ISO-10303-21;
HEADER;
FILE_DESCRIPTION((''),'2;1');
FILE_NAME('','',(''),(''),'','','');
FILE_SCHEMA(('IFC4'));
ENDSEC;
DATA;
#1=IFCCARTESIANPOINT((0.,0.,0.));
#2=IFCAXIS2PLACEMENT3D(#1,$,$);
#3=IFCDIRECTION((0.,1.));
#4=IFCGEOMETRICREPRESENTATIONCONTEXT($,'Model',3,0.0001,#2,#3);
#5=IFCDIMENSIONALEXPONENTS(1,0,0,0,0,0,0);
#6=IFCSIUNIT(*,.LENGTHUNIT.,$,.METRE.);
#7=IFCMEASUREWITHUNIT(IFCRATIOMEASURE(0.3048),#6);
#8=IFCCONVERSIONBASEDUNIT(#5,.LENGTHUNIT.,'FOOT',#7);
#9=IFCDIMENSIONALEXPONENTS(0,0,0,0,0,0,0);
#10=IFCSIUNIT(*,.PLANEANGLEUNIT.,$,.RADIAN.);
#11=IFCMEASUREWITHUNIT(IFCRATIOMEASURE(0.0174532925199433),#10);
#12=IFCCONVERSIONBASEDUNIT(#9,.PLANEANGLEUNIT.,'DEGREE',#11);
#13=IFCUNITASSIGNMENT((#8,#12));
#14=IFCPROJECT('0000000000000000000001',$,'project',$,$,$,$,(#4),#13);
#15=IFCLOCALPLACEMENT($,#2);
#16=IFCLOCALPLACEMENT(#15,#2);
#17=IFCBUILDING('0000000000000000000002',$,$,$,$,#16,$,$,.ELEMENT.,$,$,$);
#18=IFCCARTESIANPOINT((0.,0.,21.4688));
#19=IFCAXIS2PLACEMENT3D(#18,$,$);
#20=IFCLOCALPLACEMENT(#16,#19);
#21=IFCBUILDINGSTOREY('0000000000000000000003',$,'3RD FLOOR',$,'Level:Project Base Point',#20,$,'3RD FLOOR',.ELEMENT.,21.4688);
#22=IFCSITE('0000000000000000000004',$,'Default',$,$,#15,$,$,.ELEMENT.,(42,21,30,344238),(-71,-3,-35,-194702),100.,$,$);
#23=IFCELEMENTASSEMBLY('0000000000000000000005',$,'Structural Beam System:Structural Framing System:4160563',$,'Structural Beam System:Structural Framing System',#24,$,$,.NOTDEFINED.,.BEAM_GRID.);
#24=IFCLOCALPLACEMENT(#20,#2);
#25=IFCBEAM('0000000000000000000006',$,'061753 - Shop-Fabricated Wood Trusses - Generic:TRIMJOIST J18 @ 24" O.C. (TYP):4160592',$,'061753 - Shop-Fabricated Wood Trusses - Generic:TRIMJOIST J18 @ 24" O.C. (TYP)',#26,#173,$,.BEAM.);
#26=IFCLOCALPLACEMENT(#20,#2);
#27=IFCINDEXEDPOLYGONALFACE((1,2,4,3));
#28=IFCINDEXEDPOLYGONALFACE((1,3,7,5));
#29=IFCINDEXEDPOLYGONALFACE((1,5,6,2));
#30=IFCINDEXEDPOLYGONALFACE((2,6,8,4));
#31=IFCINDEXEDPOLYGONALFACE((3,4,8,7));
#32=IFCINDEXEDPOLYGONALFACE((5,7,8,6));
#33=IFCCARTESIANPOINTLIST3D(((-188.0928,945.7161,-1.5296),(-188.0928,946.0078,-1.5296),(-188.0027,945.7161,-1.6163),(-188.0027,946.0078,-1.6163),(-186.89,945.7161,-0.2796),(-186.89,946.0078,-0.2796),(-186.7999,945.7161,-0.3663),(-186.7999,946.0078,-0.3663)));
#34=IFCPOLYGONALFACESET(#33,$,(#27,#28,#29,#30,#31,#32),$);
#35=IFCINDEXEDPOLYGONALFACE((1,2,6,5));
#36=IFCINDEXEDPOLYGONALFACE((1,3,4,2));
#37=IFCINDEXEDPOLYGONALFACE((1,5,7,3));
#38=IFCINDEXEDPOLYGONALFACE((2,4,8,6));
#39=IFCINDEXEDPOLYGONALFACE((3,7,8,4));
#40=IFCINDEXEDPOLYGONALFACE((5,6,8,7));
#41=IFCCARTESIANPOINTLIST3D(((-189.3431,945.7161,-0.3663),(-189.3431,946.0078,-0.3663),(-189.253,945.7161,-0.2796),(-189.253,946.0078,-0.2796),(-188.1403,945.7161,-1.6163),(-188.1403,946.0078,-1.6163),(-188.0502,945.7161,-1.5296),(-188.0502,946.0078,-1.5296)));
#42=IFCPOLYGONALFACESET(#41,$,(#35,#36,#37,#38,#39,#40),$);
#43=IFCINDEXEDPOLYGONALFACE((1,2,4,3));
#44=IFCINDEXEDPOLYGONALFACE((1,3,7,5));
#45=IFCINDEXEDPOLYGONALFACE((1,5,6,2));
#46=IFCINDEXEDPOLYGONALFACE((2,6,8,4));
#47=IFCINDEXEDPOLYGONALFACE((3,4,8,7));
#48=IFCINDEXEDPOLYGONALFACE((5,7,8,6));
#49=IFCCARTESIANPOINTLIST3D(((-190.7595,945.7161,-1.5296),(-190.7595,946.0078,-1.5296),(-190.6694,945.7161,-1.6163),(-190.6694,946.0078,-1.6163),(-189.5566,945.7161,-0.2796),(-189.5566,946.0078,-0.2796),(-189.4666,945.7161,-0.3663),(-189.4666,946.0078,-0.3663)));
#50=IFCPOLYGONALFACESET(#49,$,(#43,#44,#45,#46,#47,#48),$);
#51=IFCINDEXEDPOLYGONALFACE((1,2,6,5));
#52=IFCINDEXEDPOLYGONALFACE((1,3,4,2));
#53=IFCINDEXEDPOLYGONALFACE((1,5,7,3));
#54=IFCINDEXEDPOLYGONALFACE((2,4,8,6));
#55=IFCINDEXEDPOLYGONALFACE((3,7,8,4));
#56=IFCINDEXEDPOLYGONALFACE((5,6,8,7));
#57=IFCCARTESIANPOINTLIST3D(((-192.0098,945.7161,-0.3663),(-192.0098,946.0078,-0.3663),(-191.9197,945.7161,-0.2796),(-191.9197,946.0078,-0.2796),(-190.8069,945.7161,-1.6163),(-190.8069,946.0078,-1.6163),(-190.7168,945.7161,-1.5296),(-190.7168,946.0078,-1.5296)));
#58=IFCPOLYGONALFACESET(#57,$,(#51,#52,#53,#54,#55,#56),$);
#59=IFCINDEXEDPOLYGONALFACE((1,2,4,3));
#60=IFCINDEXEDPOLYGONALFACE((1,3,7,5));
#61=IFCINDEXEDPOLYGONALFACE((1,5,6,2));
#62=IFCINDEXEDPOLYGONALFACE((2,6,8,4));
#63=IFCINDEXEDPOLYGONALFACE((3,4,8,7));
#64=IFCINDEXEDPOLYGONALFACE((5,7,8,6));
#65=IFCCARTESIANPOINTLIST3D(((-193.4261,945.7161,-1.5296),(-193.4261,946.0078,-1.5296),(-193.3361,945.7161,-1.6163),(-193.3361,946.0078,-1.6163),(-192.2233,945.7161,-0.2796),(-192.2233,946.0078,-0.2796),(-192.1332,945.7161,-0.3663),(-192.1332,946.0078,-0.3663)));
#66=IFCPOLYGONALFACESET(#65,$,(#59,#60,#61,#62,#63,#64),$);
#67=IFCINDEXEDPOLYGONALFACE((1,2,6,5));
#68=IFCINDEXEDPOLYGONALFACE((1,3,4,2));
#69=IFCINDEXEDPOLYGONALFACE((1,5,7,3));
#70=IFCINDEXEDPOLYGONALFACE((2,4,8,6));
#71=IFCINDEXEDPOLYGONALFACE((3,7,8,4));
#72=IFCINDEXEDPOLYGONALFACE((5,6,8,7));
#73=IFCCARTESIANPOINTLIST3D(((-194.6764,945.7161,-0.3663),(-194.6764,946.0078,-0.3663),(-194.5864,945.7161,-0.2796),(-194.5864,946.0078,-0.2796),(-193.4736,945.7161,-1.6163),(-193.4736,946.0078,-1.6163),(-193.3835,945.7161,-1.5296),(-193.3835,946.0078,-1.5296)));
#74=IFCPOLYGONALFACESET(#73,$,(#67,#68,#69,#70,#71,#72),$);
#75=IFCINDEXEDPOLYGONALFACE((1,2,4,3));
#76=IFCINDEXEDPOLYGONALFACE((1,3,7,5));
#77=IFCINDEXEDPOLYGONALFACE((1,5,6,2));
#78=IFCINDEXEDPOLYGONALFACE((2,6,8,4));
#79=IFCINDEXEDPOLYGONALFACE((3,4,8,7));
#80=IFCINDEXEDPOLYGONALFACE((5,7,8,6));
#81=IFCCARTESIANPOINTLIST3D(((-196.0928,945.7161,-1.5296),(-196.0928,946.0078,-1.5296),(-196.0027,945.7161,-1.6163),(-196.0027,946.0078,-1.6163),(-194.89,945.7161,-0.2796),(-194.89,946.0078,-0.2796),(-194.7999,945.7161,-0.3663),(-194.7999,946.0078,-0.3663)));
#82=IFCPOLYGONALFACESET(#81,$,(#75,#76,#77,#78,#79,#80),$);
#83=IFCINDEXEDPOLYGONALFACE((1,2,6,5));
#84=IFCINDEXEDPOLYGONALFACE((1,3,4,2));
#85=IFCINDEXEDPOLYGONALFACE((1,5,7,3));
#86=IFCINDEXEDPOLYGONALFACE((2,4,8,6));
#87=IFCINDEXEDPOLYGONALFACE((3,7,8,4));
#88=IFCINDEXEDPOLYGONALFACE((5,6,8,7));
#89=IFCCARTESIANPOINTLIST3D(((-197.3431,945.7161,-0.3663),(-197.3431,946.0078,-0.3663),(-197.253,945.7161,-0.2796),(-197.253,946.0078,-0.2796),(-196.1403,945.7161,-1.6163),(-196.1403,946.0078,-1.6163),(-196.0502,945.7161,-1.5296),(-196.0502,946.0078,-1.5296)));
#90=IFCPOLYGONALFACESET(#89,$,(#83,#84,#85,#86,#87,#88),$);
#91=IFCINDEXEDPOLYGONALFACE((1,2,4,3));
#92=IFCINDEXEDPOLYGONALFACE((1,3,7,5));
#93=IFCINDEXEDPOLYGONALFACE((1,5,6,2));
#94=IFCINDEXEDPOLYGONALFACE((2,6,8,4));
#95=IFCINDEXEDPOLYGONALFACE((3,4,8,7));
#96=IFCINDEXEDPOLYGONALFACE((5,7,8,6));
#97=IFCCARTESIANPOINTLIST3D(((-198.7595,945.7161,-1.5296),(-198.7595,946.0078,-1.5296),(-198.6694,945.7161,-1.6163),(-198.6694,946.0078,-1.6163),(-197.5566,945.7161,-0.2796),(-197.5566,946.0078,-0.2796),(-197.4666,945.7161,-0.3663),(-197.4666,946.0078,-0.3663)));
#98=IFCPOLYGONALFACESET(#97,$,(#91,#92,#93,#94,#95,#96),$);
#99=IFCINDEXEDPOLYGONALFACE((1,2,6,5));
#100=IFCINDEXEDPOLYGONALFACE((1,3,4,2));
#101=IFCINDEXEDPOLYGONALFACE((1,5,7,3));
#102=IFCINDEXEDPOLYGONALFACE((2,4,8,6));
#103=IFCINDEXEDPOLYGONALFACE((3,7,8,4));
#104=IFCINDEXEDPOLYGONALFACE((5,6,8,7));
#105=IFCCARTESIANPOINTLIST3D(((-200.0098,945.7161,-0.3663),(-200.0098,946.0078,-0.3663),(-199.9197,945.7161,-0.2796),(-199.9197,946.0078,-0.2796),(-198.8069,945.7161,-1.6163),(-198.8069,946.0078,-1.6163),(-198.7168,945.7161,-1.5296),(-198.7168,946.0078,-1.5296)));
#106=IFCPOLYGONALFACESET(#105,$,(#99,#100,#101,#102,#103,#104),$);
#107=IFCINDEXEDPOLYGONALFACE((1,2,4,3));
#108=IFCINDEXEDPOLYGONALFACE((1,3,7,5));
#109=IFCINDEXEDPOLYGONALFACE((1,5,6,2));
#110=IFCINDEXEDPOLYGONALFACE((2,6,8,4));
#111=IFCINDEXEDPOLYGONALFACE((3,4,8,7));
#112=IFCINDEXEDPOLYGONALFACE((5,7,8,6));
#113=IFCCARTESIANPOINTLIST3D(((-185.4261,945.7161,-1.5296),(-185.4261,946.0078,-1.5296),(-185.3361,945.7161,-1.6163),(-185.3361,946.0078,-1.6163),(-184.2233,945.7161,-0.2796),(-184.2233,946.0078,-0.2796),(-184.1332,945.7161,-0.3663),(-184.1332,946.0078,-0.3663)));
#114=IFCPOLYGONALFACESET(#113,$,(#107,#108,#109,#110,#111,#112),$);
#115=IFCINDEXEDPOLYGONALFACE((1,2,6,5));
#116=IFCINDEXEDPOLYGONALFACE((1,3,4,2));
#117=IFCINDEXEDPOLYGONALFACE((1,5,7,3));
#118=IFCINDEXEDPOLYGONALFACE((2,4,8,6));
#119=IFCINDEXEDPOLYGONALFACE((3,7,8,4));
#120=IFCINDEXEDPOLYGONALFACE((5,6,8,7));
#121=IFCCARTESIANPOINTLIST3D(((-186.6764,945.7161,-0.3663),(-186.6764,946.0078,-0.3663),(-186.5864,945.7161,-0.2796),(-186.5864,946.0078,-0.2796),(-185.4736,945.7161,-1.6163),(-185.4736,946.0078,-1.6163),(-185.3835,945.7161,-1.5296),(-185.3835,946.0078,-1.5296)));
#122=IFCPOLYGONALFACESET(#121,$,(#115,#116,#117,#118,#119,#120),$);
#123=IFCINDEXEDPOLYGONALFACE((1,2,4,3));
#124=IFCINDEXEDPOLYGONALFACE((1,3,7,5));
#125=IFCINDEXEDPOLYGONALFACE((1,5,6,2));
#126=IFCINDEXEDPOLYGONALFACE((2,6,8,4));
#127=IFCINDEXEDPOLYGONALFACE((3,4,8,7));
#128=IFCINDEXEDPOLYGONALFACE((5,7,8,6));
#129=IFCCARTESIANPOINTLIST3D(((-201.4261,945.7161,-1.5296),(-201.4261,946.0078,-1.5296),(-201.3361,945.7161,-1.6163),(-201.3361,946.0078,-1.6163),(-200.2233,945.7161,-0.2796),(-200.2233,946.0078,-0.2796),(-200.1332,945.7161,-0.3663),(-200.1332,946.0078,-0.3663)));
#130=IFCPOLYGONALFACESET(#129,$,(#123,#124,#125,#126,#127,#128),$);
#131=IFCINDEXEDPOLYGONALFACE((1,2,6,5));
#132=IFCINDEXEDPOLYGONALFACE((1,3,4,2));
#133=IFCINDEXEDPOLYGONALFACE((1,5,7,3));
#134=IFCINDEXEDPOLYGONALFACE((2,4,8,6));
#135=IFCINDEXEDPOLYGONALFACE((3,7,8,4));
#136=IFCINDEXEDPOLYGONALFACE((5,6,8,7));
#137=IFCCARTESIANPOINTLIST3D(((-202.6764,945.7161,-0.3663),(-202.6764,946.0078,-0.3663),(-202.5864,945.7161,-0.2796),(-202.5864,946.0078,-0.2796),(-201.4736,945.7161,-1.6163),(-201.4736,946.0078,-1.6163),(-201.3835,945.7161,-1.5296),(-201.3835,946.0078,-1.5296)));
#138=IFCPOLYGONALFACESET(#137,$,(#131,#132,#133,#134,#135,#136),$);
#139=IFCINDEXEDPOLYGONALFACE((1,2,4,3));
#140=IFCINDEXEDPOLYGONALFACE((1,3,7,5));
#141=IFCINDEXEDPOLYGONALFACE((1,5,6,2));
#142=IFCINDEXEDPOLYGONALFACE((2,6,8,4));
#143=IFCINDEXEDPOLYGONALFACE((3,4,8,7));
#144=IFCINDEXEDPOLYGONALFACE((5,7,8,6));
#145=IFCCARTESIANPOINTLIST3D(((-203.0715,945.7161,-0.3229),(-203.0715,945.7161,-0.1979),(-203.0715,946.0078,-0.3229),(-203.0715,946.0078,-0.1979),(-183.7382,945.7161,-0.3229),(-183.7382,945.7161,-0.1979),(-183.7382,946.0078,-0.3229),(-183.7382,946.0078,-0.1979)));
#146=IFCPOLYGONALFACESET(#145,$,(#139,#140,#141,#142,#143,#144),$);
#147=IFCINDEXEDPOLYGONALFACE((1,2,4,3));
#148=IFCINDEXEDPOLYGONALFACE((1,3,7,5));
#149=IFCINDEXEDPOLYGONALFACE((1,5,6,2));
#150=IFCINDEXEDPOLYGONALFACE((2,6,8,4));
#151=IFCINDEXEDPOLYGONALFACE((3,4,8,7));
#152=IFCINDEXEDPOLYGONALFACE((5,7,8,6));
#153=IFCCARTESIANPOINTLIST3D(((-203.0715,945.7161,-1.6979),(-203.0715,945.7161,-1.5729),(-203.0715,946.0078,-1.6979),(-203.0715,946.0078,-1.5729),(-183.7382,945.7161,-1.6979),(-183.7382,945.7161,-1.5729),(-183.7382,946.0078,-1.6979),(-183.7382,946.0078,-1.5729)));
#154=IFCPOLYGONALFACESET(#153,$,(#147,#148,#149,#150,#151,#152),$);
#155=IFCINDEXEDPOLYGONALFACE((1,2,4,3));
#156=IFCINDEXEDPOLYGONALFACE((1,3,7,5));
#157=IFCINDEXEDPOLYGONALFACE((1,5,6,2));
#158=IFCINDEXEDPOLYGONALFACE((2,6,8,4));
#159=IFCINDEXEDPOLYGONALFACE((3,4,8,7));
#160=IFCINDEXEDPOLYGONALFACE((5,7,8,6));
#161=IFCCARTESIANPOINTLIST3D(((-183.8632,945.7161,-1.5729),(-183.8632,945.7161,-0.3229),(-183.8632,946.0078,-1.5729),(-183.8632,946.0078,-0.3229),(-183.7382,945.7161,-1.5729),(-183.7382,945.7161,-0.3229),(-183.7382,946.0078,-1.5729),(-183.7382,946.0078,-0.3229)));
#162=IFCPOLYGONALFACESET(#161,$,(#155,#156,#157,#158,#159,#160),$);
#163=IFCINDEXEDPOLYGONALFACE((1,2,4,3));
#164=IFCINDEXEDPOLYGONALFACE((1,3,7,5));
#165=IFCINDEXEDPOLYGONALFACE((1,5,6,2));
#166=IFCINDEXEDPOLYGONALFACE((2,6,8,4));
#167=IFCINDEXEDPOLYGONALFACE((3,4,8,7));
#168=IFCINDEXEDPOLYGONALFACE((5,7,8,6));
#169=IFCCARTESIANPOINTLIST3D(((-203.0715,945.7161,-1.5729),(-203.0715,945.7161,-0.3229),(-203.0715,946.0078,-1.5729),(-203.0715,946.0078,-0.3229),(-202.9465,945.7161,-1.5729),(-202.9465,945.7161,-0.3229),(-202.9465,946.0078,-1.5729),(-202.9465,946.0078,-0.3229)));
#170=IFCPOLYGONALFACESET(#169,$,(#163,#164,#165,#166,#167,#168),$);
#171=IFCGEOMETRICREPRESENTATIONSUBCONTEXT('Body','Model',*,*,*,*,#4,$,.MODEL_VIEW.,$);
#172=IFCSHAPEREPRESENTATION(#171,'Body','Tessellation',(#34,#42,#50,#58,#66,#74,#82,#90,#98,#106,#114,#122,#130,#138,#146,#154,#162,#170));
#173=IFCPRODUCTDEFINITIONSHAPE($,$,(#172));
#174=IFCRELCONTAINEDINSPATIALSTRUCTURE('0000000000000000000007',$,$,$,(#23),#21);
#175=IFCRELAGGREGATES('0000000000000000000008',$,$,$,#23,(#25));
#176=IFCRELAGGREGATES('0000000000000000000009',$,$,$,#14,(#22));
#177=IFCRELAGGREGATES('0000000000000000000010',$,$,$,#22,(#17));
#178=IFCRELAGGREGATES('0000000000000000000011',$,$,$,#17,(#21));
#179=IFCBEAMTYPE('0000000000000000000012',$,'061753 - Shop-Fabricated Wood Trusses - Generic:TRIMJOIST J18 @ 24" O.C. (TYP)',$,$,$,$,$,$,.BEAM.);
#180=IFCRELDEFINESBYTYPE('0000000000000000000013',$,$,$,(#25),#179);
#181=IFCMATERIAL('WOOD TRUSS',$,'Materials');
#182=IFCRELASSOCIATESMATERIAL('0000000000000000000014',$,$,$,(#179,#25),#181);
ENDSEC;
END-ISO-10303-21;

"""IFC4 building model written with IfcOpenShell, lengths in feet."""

from ifc_helpers import new_model, entity, si_unit, converted_unit, direction, frame, frame_2d, origin, origin_2d_with_axis, place, context, subcontext, project, spatial, rectangle, extrude, source, transform, mapped, material, material_profile, profile_set, profile_usage, type_object, type_shapes, element, aggregate, save


model = new_model("IFC4")

# Units and contexts
model_context = context("Model", 3, precision=0.0001, world=origin(), true_north=direction((0.0, 1.0)))
body_context = subcontext(model_context, "Body", "Model", "MODEL_VIEW")
ifc_project = project(units=[converted_unit("LENGTHUNIT", "FOOT", entity("IfcRatioMeasure", 0.3048), si_unit("LENGTHUNIT", "METRE"), dimensions=[1, 0, 0, 0, 0, 0, 0]), converted_unit("PLANEANGLEUNIT", "DEGREE", entity("IfcRatioMeasure", 0.0174532925199433), si_unit("PLANEANGLEUNIT", "RADIAN"), dimensions=[0, 0, 0, 0, 0, 0, 0])], contexts=[model_context])

# Site, building, storey
site_placement = place(None, origin())
site = spatial("IfcSite", under=ifc_project, at=site_placement, Name="Default", CompositionType="ELEMENT", RefLatitude=(42, 21, 30, 344238), RefLongitude=(-71, -3, -35, -194702), RefElevation=100.0)
building_placement = place(site_placement, origin())
building = spatial("IfcBuilding", under=site, at=building_placement, CompositionType="ELEMENT")
storey_placement = place(building_placement, frame((0.0, 0.0, 21.4688)))
storey = spatial("IfcBuildingStorey", under=building, at=storey_placement, Name="3RD FLOOR", ObjectType="Level:Project Base Point", LongName="3RD FLOOR", CompositionType="ELEMENT", Elevation=21.4688)

# Element assembly, beam
ifc_material = material(Name="WOOD TRUSS", Category="Materials")
ifc_material_profile_1 = material_profile(ifc_material, rectangle(XDim=1.7347, YDim=0.125, at=frame_2d((0.0, 0.0), x_axis=(1.0, 0.0))), Name="TRIMJOIST J18 @ 24\" O.C. (TYP)")
ifc_material_profile_2 = material_profile(ifc_material, rectangle(XDim=1.7347, YDim=0.125, at=frame_2d((0.0, 0.0), x_axis=(1.0, 0.0))), Name="TRIMJOIST J18 @ 24\" O.C. (TYP)")
ifc_material_profile_3 = material_profile(ifc_material, rectangle(XDim=1.7347, YDim=0.125, at=frame_2d((0.0, 0.0), x_axis=(1.0, 0.0))), Name="TRIMJOIST J18 @ 24\" O.C. (TYP)")
ifc_material_profile_4 = material_profile(ifc_material, rectangle(XDim=1.7347, YDim=0.125, at=frame_2d((0.0, 0.0), x_axis=(1.0, 0.0))), Name="TRIMJOIST J18 @ 24\" O.C. (TYP)")
ifc_material_profile_5 = material_profile(ifc_material, rectangle(XDim=1.7347, YDim=0.125, at=frame_2d((0.0, 0.0), x_axis=(1.0, 0.0))), Name="TRIMJOIST J18 @ 24\" O.C. (TYP)")
ifc_material_profile_6 = material_profile(ifc_material, rectangle(XDim=1.7347, YDim=0.125, at=frame_2d((0.0, 0.0), x_axis=(1.0, 0.0))), Name="TRIMJOIST J18 @ 24\" O.C. (TYP)")
ifc_material_profile_7 = material_profile(ifc_material, rectangle(XDim=1.7347, YDim=0.125, at=frame_2d((0.0, 0.0), x_axis=(1.0, 0.0))), Name="TRIMJOIST J18 @ 24\" O.C. (TYP)")
ifc_material_profile_8 = material_profile(ifc_material, rectangle(XDim=1.7347, YDim=0.125, at=frame_2d((0.0, 0.0), x_axis=(1.0, 0.0))), Name="TRIMJOIST J18 @ 24\" O.C. (TYP)")
ifc_material_profile_9 = material_profile(ifc_material, rectangle(XDim=1.7347, YDim=0.125, at=frame_2d((0.0, 0.0), x_axis=(1.0, 0.0))), Name="TRIMJOIST J18 @ 24\" O.C. (TYP)")
ifc_material_profile_10 = material_profile(ifc_material, rectangle(XDim=1.7347, YDim=0.125, at=origin_2d_with_axis()), Name="TRIMJOIST J18 @ 24\" O.C. (TYP)")
ifc_material_profile_11 = material_profile(ifc_material, rectangle(XDim=0.125, YDim=0.2917, at=origin_2d_with_axis()), Name="TRIMJOIST J18 @ 24\" O.C. (TYP)")
ifc_material_profile_12 = material_profile(ifc_material, rectangle(XDim=0.125, YDim=0.2917, at=origin_2d_with_axis()), Name="TRIMJOIST J18 @ 24\" O.C. (TYP)")
ifc_material_profile_13 = material_profile(ifc_material, rectangle(XDim=1.25, YDim=0.2917, at=origin_2d_with_axis()), Name="TRIMJOIST J18 @ 24\" O.C. (TYP)")
ifc_material_profile_14 = material_profile(ifc_material, rectangle(XDim=1.25, YDim=0.2917, at=origin_2d_with_axis()), Name="TRIMJOIST J18 @ 24\" O.C. (TYP)")
ifc_profile_set = profile_set([ifc_material_profile_1, ifc_material_profile_2, ifc_material_profile_3, ifc_material_profile_4, ifc_material_profile_5, ifc_material_profile_6, ifc_material_profile_7, ifc_material_profile_8, ifc_material_profile_9, ifc_material_profile_10, ifc_material_profile_11, ifc_material_profile_12, ifc_material_profile_13, ifc_material_profile_14], Name="TRIMJOIST J18 @ 24\" O.C. (TYP)")
beam_type_1 = type_object("IfcBeamType", Name="061753 - Shop-Fabricated Wood Trusses - Generic:TRIMJOIST J18 @ 24\" O.C. (TYP)", PredefinedType="BEAM", material=ifc_profile_set)
shared_shape_1 = source(origin(), body_context, "Body", "SweptSolid", [
    extrude(rectangle(XDim=1.7347, YDim=0.125, at=frame_2d((0.0, 0.0), x_axis=(1.0, 0.0))), frame((5.9585, -0.1458, 0.0), z_axis=(0.0, 1.0, 0.0), x_axis=(0.693383, 0.0, 0.720569)), (0.0, 0.0, 1.0), 0.2917),
    extrude(rectangle(XDim=1.7347, YDim=0.125, at=origin_2d_with_axis()), frame((4.7082, -0.1458, 0.0), z_axis=(0.0, 1.0, 0.0), x_axis=(0.693383, 0.0, -0.720569)), (0.0, 0.0, 1.0), 0.2917),
    extrude(rectangle(XDim=1.7347, YDim=0.125, at=frame_2d((0.0, 0.0), x_axis=(1.0, 0.0))), frame((3.2918, -0.1458, 0.0), z_axis=(0.0, 1.0, 0.0), x_axis=(0.693383, 0.0, 0.720569)), (0.0, 0.0, 1.0), 0.2917),
    extrude(rectangle(XDim=1.7347, YDim=0.125, at=frame_2d((0.0, 0.0), x_axis=(1.0, 0.0))), frame((2.0415, -0.1458, 0.0), z_axis=(0.0, 1.0, 0.0), x_axis=(0.693383, 0.0, -0.720569)), (0.0, 0.0, 1.0), 0.2917),
    extrude(rectangle(XDim=1.7347, YDim=0.125, at=frame_2d((0.0, 0.0), x_axis=(1.0, 0.0))), frame((0.6251, -0.1458, 0.0), z_axis=(0.0, 1.0, 0.0), x_axis=(0.693383, 0.0, 0.720569)), (0.0, 0.0, 1.0), 0.2917),
    extrude(rectangle(XDim=1.7347, YDim=0.125, at=frame_2d((0.0, 0.0), x_axis=(1.0, 0.0))), frame((-0.6251, -0.1458, 0.0), z_axis=(0.0, 1.0, 0.0), x_axis=(0.693383, 0.0, -0.720569)), (0.0, 0.0, 1.0), 0.2917),
    extrude(rectangle(XDim=1.7347, YDim=0.125, at=frame_2d((0.0, 0.0), x_axis=(1.0, 0.0))), frame((-2.0415, -0.1458, 0.0), z_axis=(0.0, 1.0, 0.0), x_axis=(0.693383, 0.0, 0.720569)), (0.0, 0.0, 1.0), 0.2917),
    extrude(rectangle(XDim=1.7347, YDim=0.125, at=origin_2d_with_axis()), frame((-3.2918, -0.1458, 0.0), z_axis=(0.0, 1.0, 0.0), x_axis=(0.693383, 0.0, -0.720569)), (0.0, 0.0, 1.0), 0.2917),
    extrude(rectangle(XDim=1.7347, YDim=0.125, at=frame_2d((0.0, 0.0), x_axis=(1.0, 0.0))), frame((-4.7082, -0.1458, 0.0), z_axis=(0.0, 1.0, 0.0), x_axis=(0.693383, 0.0, 0.720569)), (0.0, 0.0, 1.0), 0.2917),
    extrude(rectangle(XDim=1.7347, YDim=0.125, at=frame_2d((0.0, 0.0), x_axis=(1.0, 0.0))), frame((-5.9585, -0.1458, 0.0), z_axis=(0.0, 1.0, 0.0), x_axis=(0.693383, 0.0, -0.720569)), (0.0, 0.0, 1.0), 0.2917),
    extrude(rectangle(XDim=1.7347, YDim=0.125, at=frame_2d((0.0, 0.0), x_axis=(1.0, 0.0))), frame((8.6251, -0.1458, 0.0), z_axis=(0.0, 1.0, 0.0), x_axis=(0.693383, 0.0, 0.720569)), (0.0, 0.0, 1.0), 0.2917),
    extrude(rectangle(XDim=1.7347, YDim=0.125, at=origin_2d_with_axis()), frame((7.3749, -0.1458, 0.0), z_axis=(0.0, 1.0, 0.0), x_axis=(0.693383, 0.0, -0.720569)), (0.0, 0.0, 1.0), 0.2917),
    extrude(rectangle(XDim=1.7347, YDim=0.125, at=frame_2d((0.0, 0.0), x_axis=(1.0, 0.0))), frame((-7.3749, -0.1458, 0.0), z_axis=(0.0, 1.0, 0.0), x_axis=(0.693383, 0.0, 0.720569)), (0.0, 0.0, 1.0), 0.2917),
    extrude(rectangle(XDim=1.7347, YDim=0.125, at=origin_2d_with_axis()), frame((-8.6251, -0.1458, 0.0), z_axis=(0.0, 1.0, 0.0), x_axis=(0.693383, 0.0, -0.720569)), (0.0, 0.0, 1.0), 0.2917),
    extrude(rectangle(XDim=0.125, YDim=0.2917, at=origin_2d_with_axis()), frame((-9.6667, 0.0, 0.6875), z_axis=(1.0, 0.0, 0.0), x_axis=(0.0, 0.0, -1.0)), (0.0, 0.0, 1.0), 19.3333),
    extrude(rectangle(XDim=0.125, YDim=0.2917, at=origin_2d_with_axis()), frame((-9.6667, 0.0, -0.6875), z_axis=(1.0, 0.0, 0.0), x_axis=(0.0, 0.0, -1.0)), (0.0, 0.0, 1.0), 19.3333),
    extrude(rectangle(XDim=1.25, YDim=0.2917, at=origin_2d_with_axis()), frame((9.5417, 0.0, 0.0), z_axis=(1.0, 0.0, 0.0), x_axis=(0.0, 0.0, -1.0)), (0.0, 0.0, 1.0), 0.125),
    extrude(rectangle(XDim=1.25, YDim=0.2917, at=origin_2d_with_axis()), frame((-9.6667, 0.0, 0.0), z_axis=(1.0, 0.0, 0.0), x_axis=(0.0, 0.0, -1.0)), (0.0, 0.0, 1.0), 0.125),
])
type_shapes(beam_type_1, [shared_shape_1])
assembly_1_placement = place(storey_placement, origin())
assembly_1 = element("IfcElementAssembly", 1, at=assembly_1_placement, inside=storey, Name="Structural Beam System:Structural Framing System:4160563", ObjectType="Structural Beam System:Structural Framing System", AssemblyPlace="NOTDEFINED", PredefinedType="BEAM_GRID")
ifc_profile_usage_1 = profile_usage(ifc_profile_set, cardinal=8)
beam_1_placement = place(assembly_1_placement, frame((-193.4048, 945.8619, -0.9479)))
beam_1 = element("IfcBeam", 2, at=beam_1_placement, type_object=beam_type_1, material=ifc_profile_usage_1, Name="061753 - Shop-Fabricated Wood Trusses - Generic:TRIMJOIST J18 @ 24\" O.C. (TYP):4160592", ObjectType="061753 - Shop-Fabricated Wood Trusses - Generic:TRIMJOIST J18 @ 24\" O.C. (TYP)", PredefinedType="BEAM", context=body_context, shape_type="MappedRepresentation", body=[
    mapped(shared_shape_1, transform((0.0, 0.0, 0.0), scale=1.0)),
])
aggregate(assembly_1, [beam_1])

save(model, "model.ifc")
